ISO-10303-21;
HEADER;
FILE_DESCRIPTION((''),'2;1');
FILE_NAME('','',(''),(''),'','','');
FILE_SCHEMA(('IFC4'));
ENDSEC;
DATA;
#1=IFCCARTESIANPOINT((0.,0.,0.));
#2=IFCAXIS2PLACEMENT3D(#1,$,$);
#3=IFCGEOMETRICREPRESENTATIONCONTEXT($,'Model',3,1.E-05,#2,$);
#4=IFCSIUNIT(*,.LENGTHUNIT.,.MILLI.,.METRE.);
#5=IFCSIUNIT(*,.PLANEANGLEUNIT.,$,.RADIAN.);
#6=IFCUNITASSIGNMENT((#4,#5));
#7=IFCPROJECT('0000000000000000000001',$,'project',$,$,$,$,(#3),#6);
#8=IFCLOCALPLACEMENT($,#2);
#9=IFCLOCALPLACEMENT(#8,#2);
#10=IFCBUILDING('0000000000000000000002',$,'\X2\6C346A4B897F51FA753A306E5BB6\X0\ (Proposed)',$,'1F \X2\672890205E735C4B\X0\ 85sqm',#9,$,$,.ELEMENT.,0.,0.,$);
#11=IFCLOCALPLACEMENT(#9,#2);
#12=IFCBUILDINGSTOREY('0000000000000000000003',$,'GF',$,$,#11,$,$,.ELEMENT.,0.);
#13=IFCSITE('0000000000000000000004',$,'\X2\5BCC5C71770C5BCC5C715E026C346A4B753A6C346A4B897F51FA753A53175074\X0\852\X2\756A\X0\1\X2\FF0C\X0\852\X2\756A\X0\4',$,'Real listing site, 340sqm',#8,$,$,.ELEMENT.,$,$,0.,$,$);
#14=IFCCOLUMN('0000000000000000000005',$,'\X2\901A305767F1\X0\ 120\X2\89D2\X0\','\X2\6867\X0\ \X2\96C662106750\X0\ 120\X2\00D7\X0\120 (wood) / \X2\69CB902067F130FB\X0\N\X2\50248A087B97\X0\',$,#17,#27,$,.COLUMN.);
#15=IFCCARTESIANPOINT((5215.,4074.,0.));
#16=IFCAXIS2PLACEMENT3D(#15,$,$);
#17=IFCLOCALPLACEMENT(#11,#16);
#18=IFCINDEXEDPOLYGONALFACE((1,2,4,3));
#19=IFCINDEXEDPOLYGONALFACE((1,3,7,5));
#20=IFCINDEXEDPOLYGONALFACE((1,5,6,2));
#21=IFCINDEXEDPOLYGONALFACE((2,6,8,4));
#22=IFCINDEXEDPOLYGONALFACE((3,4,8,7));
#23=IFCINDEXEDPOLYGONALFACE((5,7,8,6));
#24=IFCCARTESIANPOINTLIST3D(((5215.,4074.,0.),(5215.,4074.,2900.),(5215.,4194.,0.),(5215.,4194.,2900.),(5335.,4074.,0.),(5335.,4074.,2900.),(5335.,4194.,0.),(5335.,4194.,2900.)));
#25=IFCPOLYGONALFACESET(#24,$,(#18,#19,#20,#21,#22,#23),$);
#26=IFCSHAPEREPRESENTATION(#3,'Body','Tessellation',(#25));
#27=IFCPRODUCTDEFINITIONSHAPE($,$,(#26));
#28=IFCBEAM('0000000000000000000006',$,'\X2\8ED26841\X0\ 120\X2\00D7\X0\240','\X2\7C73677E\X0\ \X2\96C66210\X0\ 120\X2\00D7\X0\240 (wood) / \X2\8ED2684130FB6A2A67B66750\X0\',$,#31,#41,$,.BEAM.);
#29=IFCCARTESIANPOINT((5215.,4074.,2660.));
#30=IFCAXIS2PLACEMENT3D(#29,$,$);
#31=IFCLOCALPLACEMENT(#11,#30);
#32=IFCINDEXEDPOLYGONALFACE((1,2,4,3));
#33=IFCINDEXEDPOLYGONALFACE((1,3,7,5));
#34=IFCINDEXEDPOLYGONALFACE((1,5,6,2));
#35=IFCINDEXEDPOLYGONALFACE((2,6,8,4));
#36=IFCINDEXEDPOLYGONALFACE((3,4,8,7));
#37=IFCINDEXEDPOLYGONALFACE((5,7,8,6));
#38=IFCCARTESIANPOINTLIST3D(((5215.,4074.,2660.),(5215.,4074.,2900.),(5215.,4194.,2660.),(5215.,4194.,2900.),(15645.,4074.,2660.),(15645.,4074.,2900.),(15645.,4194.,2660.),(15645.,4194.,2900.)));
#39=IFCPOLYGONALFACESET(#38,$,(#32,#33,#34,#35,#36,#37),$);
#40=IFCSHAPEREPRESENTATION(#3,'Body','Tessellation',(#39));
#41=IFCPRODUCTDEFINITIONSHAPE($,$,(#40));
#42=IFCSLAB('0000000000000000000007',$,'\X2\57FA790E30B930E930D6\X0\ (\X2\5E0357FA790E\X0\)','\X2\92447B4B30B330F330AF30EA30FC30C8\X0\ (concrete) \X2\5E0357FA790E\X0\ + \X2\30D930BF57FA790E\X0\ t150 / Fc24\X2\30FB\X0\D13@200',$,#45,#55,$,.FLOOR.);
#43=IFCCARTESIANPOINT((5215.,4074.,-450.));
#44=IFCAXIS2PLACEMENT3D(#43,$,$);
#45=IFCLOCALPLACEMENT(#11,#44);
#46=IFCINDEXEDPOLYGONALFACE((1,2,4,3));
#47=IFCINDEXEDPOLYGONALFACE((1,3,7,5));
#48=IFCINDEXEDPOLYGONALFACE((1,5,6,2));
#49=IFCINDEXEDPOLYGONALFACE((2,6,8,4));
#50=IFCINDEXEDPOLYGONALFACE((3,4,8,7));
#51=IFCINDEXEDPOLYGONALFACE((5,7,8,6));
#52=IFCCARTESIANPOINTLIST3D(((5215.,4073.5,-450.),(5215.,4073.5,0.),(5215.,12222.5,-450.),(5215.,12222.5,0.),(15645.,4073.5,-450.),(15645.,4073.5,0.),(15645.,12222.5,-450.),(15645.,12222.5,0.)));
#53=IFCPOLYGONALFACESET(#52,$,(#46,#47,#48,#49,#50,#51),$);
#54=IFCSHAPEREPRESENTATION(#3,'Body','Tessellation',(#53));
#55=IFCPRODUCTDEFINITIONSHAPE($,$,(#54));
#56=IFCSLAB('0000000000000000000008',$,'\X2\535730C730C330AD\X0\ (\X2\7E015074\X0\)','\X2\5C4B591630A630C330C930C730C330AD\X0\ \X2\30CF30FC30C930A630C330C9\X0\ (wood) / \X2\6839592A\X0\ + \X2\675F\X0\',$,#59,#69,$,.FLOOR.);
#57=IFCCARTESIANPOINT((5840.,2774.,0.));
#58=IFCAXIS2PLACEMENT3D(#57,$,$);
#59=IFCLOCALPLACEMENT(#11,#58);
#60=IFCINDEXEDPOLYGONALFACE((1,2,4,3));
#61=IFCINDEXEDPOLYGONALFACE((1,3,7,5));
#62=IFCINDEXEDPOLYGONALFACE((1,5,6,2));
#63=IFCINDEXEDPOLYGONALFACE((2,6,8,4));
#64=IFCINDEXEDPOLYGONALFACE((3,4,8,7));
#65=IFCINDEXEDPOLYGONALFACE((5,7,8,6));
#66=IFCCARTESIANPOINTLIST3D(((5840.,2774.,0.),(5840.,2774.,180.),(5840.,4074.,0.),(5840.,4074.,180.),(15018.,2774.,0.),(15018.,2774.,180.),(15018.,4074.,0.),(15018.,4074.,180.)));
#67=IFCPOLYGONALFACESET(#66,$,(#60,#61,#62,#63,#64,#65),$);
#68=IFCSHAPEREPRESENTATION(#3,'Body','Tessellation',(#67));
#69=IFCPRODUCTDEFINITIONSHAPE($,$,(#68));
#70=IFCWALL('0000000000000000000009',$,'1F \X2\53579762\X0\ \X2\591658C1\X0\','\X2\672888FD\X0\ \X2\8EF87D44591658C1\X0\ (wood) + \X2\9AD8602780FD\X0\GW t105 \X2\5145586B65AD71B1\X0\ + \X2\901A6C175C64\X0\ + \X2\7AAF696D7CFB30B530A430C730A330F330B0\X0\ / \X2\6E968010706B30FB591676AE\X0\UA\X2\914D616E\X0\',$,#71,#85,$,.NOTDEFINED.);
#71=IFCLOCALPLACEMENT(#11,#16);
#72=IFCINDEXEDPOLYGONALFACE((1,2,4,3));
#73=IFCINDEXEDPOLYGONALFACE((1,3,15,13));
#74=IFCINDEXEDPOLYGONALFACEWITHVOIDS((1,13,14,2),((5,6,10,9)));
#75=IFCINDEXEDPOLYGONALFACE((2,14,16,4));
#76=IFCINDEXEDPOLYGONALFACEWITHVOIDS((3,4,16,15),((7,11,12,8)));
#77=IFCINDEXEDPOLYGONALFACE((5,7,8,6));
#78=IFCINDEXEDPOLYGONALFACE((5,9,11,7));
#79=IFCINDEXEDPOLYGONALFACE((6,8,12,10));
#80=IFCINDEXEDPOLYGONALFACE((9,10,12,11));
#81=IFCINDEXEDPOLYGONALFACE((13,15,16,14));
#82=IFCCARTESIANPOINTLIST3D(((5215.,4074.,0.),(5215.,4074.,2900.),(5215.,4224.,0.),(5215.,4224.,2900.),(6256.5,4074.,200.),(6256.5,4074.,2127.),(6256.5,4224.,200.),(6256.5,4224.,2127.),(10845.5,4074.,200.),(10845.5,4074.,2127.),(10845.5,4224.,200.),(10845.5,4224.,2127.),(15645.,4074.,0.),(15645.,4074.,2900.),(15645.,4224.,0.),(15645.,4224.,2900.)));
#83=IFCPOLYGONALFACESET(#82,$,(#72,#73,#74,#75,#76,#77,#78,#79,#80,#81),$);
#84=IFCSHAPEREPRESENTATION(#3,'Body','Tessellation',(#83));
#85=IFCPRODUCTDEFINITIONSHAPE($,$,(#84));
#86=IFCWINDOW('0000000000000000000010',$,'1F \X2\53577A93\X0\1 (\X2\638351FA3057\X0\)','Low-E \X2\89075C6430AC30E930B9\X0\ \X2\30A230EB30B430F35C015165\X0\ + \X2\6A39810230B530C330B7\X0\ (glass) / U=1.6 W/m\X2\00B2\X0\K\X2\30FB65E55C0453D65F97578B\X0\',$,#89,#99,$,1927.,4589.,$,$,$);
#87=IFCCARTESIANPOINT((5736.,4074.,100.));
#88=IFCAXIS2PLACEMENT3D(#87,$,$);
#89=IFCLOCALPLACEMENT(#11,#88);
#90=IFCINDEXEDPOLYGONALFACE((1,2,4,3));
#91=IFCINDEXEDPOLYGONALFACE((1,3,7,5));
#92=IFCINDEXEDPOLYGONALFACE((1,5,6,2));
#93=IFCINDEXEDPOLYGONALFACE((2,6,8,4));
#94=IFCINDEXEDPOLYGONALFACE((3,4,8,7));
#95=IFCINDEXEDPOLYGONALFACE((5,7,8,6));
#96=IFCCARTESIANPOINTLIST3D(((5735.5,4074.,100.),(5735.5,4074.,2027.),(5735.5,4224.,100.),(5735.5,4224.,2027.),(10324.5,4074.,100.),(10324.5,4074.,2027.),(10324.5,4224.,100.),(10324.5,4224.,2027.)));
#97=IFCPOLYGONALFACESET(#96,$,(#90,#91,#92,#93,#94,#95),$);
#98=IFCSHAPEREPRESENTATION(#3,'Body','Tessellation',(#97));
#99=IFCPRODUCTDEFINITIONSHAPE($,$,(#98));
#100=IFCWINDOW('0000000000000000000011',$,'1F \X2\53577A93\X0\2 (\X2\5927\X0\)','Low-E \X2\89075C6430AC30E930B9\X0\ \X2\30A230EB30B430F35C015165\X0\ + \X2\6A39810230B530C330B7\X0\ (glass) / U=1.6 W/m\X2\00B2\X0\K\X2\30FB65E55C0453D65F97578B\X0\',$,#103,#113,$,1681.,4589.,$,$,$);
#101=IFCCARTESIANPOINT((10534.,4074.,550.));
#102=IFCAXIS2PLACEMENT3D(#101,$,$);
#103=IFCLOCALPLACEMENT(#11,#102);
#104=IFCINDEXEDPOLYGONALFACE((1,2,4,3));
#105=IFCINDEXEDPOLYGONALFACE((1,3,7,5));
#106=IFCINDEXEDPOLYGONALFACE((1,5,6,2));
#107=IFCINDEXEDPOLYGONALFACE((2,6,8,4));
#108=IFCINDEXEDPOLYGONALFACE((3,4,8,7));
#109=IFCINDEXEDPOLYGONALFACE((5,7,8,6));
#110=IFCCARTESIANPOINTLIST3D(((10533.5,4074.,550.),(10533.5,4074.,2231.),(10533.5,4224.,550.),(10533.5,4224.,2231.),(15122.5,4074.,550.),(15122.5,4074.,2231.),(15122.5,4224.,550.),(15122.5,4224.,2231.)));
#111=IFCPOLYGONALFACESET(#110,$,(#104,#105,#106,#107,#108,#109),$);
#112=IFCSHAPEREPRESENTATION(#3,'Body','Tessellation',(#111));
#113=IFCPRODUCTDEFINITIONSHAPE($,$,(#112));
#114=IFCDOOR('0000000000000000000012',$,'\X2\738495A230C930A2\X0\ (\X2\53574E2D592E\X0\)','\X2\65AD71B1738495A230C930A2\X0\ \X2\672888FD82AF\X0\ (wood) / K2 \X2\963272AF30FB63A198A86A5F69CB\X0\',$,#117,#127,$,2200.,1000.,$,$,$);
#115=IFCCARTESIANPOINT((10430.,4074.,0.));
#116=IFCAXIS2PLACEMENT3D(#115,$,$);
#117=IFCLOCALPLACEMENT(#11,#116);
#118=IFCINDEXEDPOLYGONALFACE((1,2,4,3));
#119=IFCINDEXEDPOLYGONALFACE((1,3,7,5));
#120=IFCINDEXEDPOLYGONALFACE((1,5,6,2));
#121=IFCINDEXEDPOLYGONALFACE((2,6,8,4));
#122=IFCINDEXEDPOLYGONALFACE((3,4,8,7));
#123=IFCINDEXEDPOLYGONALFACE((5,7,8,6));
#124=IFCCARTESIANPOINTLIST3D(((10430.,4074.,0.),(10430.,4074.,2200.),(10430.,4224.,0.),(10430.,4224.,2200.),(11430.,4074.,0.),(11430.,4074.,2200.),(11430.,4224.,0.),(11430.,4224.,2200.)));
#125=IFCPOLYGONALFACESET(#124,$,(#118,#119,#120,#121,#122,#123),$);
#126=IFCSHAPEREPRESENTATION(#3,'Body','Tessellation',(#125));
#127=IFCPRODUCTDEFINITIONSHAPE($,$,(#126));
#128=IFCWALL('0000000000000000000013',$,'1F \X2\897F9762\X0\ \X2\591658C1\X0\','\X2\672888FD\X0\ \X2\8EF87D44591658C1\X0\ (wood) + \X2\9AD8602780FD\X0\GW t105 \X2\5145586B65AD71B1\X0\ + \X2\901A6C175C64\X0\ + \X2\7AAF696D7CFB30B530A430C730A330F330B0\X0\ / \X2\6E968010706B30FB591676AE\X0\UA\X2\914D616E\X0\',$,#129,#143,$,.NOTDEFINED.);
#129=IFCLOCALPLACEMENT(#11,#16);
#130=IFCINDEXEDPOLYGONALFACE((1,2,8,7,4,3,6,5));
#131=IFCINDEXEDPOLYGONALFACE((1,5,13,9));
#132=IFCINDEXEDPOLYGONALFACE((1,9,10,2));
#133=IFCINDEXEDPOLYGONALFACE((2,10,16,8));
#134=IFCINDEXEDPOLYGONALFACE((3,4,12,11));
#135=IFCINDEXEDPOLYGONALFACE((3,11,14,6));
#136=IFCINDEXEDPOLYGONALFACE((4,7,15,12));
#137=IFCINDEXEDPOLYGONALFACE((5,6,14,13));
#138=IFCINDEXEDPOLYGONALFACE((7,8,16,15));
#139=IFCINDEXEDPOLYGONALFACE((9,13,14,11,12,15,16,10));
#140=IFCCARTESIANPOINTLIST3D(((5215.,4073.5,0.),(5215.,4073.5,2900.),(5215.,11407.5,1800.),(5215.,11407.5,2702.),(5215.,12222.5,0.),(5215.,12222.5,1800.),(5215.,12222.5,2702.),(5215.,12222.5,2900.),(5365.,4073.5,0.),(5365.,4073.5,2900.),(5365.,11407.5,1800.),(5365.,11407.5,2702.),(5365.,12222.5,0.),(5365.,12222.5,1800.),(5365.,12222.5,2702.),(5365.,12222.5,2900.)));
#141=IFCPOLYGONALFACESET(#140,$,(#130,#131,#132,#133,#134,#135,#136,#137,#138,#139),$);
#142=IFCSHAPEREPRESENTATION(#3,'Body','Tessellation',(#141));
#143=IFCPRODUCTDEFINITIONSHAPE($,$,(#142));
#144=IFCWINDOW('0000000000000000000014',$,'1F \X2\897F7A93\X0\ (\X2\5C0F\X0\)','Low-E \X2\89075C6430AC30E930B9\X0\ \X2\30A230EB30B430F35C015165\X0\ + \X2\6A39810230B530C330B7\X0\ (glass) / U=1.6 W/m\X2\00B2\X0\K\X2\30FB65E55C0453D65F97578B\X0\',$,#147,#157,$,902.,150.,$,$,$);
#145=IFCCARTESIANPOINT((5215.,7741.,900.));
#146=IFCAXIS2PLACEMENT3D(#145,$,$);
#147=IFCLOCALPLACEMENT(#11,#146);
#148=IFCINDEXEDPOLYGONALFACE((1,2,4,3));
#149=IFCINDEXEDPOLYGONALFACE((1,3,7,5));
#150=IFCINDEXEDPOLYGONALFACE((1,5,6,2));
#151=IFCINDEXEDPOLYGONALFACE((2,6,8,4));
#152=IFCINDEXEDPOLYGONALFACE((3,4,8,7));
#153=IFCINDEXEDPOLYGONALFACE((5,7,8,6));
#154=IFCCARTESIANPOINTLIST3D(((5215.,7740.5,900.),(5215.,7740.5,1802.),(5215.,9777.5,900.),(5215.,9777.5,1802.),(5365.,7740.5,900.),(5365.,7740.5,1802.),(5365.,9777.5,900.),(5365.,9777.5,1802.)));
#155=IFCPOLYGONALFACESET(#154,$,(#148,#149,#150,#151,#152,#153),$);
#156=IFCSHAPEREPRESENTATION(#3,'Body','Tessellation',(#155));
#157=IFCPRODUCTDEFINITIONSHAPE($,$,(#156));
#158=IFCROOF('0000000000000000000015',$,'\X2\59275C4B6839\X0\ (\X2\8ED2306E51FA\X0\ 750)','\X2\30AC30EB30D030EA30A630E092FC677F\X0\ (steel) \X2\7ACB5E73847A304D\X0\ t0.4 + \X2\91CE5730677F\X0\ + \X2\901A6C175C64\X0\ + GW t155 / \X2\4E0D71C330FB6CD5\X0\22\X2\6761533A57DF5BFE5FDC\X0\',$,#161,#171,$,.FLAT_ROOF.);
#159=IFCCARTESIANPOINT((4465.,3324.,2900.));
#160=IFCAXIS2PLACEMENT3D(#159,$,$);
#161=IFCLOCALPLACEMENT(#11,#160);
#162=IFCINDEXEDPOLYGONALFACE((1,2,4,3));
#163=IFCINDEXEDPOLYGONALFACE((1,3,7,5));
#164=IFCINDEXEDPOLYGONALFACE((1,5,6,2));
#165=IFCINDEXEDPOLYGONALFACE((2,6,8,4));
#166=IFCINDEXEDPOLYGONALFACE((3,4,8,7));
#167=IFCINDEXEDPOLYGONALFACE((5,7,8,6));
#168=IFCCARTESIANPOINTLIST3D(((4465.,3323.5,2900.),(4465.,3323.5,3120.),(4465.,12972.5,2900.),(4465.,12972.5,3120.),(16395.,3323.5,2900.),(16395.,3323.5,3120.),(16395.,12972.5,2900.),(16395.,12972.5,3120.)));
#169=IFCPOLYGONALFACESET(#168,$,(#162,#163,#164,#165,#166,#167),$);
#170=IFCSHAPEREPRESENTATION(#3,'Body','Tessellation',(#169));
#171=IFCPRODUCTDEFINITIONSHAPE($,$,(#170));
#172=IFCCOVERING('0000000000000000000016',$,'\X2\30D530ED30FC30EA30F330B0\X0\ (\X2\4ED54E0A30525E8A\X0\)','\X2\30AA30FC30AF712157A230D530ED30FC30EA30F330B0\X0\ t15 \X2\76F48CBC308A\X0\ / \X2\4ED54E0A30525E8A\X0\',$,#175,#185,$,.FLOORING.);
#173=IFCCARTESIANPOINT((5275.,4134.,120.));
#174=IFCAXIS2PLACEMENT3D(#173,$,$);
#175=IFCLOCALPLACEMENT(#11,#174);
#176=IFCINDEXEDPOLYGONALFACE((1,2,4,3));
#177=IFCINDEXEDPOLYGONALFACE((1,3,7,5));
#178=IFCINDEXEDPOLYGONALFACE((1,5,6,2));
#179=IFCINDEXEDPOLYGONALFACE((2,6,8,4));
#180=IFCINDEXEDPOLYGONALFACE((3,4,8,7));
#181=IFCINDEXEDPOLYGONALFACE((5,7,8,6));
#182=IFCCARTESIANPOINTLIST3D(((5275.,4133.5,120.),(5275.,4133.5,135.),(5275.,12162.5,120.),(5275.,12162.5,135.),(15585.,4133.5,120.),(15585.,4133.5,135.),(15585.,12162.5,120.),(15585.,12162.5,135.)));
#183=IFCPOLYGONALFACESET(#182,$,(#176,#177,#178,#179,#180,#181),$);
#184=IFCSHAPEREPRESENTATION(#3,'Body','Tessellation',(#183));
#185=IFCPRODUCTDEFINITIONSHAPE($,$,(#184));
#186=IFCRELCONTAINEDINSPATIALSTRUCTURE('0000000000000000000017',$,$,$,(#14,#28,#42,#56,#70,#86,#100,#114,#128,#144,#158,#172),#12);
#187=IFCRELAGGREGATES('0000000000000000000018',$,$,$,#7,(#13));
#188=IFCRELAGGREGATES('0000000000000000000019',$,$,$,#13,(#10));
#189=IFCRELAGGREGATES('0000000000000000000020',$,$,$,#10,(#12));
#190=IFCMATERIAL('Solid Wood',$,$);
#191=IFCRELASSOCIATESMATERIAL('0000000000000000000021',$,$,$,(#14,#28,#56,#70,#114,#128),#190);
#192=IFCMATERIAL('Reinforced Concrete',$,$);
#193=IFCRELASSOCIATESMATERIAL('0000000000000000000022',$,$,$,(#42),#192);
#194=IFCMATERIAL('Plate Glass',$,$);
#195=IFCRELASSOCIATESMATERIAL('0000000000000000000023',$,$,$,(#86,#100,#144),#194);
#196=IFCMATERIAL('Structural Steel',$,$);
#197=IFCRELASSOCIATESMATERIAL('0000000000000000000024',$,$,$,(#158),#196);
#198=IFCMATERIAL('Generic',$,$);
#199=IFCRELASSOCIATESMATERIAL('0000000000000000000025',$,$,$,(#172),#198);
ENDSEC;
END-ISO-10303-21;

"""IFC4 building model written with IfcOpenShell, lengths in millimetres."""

from ifc_helpers import new_model, si_unit, frame, frame_2d, origin, place, context, project, spatial, rectangle, extrude, material, element, fill, save


model = new_model("IFC4")

# Units and contexts
model_context = context("Model", 3, precision=1e-05, world=origin())
ifc_project = project(units=[si_unit("LENGTHUNIT", "METRE", prefix="MILLI"), si_unit("PLANEANGLEUNIT", "RADIAN")], contexts=[model_context])

# Site, building, storey
site_placement = place(None, origin())
site = spatial("IfcSite", under=ifc_project, at=site_placement, Name="富山県富山市水橋町水橋西出町北側852番1，852番4", ObjectType="Real listing site, 340sqm", CompositionType="ELEMENT", RefElevation=0.0)
building_placement = place(site_placement, origin())
building = spatial("IfcBuilding", under=site, at=building_placement, Name="水橋西出町の家 (Proposed)", ObjectType="1F 木造平屋 85sqm", CompositionType="ELEMENT", ElevationOfRefHeight=0.0, ElevationOfTerrain=0.0)
storey_placement = place(building_placement, origin())
storey = spatial("IfcBuildingStorey", under=building, at=storey_placement, Name="GF", CompositionType="ELEMENT", Elevation=0.0)

# Column
ifc_material_1 = material(Name="Solid Wood")
column_1_placement = place(storey_placement, frame((5215.0, 4074.0, 0.0)))
element("IfcColumn", 1, at=column_1_placement, inside=storey, material=ifc_material_1, Name="通し柱 120角", Description="桧 集成材 120×120 (wood) / 構造柱・N値計算", PredefinedType="COLUMN", context=model_context, shape_type="SweptSolid", body=[
    extrude(rectangle(XDim=120.0, YDim=120.0, at=frame_2d((60.0, 60.0))), frame((5215.0, 4074.0, 0.0)), (0.0, 0.0, 1.0), 2900.0),
])

# Beam
beam_1_placement = place(storey_placement, frame((5215.0, 4074.0, 2660.0)))
element("IfcBeam", 2, at=beam_1_placement, inside=storey, material=ifc_material_1, Name="軒桁 120×240", Description="米松 集成 120×240 (wood) / 軒桁・横架材", PredefinedType="BEAM", context=model_context, shape_type="SweptSolid", body=[
    extrude(rectangle(XDim=10430.0, YDim=120.0, at=frame_2d((5215.0, 60.0))), frame((5215.0, 4074.0, 2660.0)), (0.0, 0.0, 1.0), 240.0),
])

# Slabs
ifc_material_2 = material(Name="Reinforced Concrete")
slab_1_placement = place(storey_placement, frame((5215.0, 4074.0, -450.0)))
element("IfcSlab", 3, at=slab_1_placement, inside=storey, material=ifc_material_2, Name="基礎スラブ (布基礎)", Description="鉄筋コンクリート (concrete) 布基礎 + ベタ基礎 t150 / Fc24・D13@200", PredefinedType="FLOOR", context=model_context, shape_type="SweptSolid", body=[
    extrude(rectangle(XDim=10430.0, YDim=8149.0, at=frame_2d((5215.0, 4074.0))), frame((5215.0, 4074.0, -450.0)), (0.0, 0.0, 1.0), 450.0),
])
slab_2_placement = place(storey_placement, frame((5840.0, 2774.0, 0.0)))
element("IfcSlab", 4, at=slab_2_placement, inside=storey, material=ifc_material_1, Name="南デッキ (縁側)", Description="屋外ウッドデッキ ハードウッド (wood) / 根太 + 束", PredefinedType="FLOOR", context=model_context, shape_type="SweptSolid", body=[
    extrude(rectangle(XDim=9178.0, YDim=1300.0, at=frame_2d((4589.0, 650.0))), frame((5840.0, 2774.0, 0.0)), (0.0, 0.0, 1.0), 180.0),
])

# Wall, openings, windows, door
wall_1_placement = place(storey_placement, frame((5215.0, 4074.0, 0.0)))
wall_1 = element("IfcWall", 5, at=wall_1_placement, inside=storey, material=ifc_material_1, Name="1F 南面 外壁", Description="木製 軸組外壁 (wood) + 高性能GW t105 充填断熱 + 通気層 + 窯業系サイディング / 準耐火・外皮UA配慮", PredefinedType="NOTDEFINED", context=model_context, shape_type="SweptSolid", body=[
    extrude(rectangle(XDim=10430.0, YDim=150.0, at=frame_2d((5215.0, 75.0))), frame((5215.0, 4074.0, 0.0)), (0.0, 0.0, 1.0), 2900.0),
])
opening_1_placement = place(storey_placement, frame((5736.0, 4074.0, 100.0)))
opening_1 = element("IfcOpeningElement", 6, at=opening_1_placement, cuts=wall_1, PredefinedType="NOTDEFINED", context=model_context, shape_type="SweptSolid", body=[
    extrude(rectangle(XDim=4589.0, YDim=150.0, at=frame_2d((2294.0, 75.0))), frame((5736.0, 4074.0, 100.0)), (0.0, 0.0, 1.0), 1927.0),
])
opening_2_placement = place(storey_placement, frame((10534.0, 4074.0, 550.0)))
opening_2 = element("IfcOpeningElement", 7, at=opening_2_placement, cuts=wall_1, PredefinedType="NOTDEFINED", context=model_context, shape_type="SweptSolid", body=[
    extrude(rectangle(XDim=4589.0, YDim=150.0, at=frame_2d((2294.0, 75.0))), frame((10534.0, 4074.0, 550.0)), (0.0, 0.0, 1.0), 1681.0),
])
opening_3_placement = place(storey_placement, frame((10430.0, 4074.0, 0.0)))
opening_3 = element("IfcOpeningElement", 8, at=opening_3_placement, cuts=wall_1, PredefinedType="NOTDEFINED", context=model_context, shape_type="SweptSolid", body=[
    extrude(rectangle(XDim=1000.0, YDim=150.0, at=frame_2d((500.0, 75.0))), frame((10430.0, 4074.0, 0.0)), (0.0, 0.0, 1.0), 2200.0),
])
ifc_material_3 = material(Name="Plate Glass")
window_1_placement = place(storey_placement, frame((5736.0, 4074.0, 100.0)))
window_1 = element("IfcWindow", 9, at=window_1_placement, inside=storey, material=ifc_material_3, Name="1F 南窓1 (掃出し)", Description="Low-E 複層ガラス アルゴン封入 + 樹脂サッシ (glass) / U=1.6 W/m²K・日射取得型", OverallHeight=1927.0, OverallWidth=4589.0, context=model_context, shape_type="SweptSolid", body=[
    extrude(rectangle(XDim=4589.0, YDim=150.0, at=frame_2d((2294.0, 75.0))), frame((5736.0, 4074.0, 100.0)), (0.0, 0.0, 1.0), 1927.0),
])
fill(opening_1, window_1)
window_2_placement = place(storey_placement, frame((10534.0, 4074.0, 550.0)))
window_2 = element("IfcWindow", 10, at=window_2_placement, inside=storey, material=ifc_material_3, Name="1F 南窓2 (大)", Description="Low-E 複層ガラス アルゴン封入 + 樹脂サッシ (glass) / U=1.6 W/m²K・日射取得型", OverallHeight=1681.0, OverallWidth=4589.0, context=model_context, shape_type="SweptSolid", body=[
    extrude(rectangle(XDim=4589.0, YDim=150.0, at=frame_2d((2294.0, 75.0))), frame((10534.0, 4074.0, 550.0)), (0.0, 0.0, 1.0), 1681.0),
])
fill(opening_2, window_2)
door_placement = place(storey_placement, frame((10430.0, 4074.0, 0.0)))
door = element("IfcDoor", 11, at=door_placement, inside=storey, material=ifc_material_1, Name="玄関ドア (南中央)", Description="断熱玄関ドア 木製芯 (wood) / K2 防犯・採風機構", OverallHeight=2200.0, OverallWidth=1000.0, context=model_context, shape_type="SweptSolid", body=[
    extrude(rectangle(XDim=1000.0, YDim=150.0, at=frame_2d((500.0, 75.0))), frame((10430.0, 4074.0, 0.0)), (0.0, 0.0, 1.0), 2200.0),
])
fill(opening_3, door)

# Wall, opening, window
wall_2_placement = place(storey_placement, frame((5215.0, 4074.0, 0.0)))
wall_2 = element("IfcWall", 12, at=wall_2_placement, inside=storey, material=ifc_material_1, Name="1F 西面 外壁", Description="木製 軸組外壁 (wood) + 高性能GW t105 充填断熱 + 通気層 + 窯業系サイディング / 準耐火・外皮UA配慮", PredefinedType="NOTDEFINED", context=model_context, shape_type="SweptSolid", body=[
    extrude(rectangle(XDim=150.0, YDim=8149.0, at=frame_2d((75.0, 4074.0))), frame((5215.0, 4074.0, 0.0)), (0.0, 0.0, 1.0), 2900.0),
])
opening_4_placement = place(storey_placement, frame((5215.0, 7741.0, 900.0)))
opening_4 = element("IfcOpeningElement", 13, at=opening_4_placement, cuts=wall_2, PredefinedType="NOTDEFINED", context=model_context, shape_type="SweptSolid", body=[
    extrude(rectangle(XDim=150.0, YDim=2037.0, at=frame_2d((75.0, 1018.0))), frame((5215.0, 7741.0, 900.0)), (0.0, 0.0, 1.0), 902.0),
])
window_3_placement = place(storey_placement, frame((5215.0, 7741.0, 900.0)))
window_3 = element("IfcWindow", 14, at=window_3_placement, inside=storey, material=ifc_material_3, Name="1F 西窓 (小)", Description="Low-E 複層ガラス アルゴン封入 + 樹脂サッシ (glass) / U=1.6 W/m²K・日射取得型", OverallHeight=902.0, OverallWidth=150.0, context=model_context, shape_type="SweptSolid", body=[
    extrude(rectangle(XDim=150.0, YDim=2037.0, at=frame_2d((75.0, 1018.0))), frame((5215.0, 7741.0, 900.0)), (0.0, 0.0, 1.0), 902.0),
])
fill(opening_4, window_3)

# Roof
ifc_material_4 = material(Name="Structural Steel")
roof_placement = place(storey_placement, frame((4465.0, 3324.0, 2900.0)))
element("IfcRoof", 15, at=roof_placement, inside=storey, material=ifc_material_4, Name="大屋根 (軒の出 750)", Description="ガルバリウム鋼板 (steel) 立平葺き t0.4 + 野地板 + 通気層 + GW t155 / 不燃・法22条区域対応", PredefinedType="FLAT_ROOF", context=model_context, shape_type="SweptSolid", body=[
    extrude(rectangle(XDim=11930.0, YDim=9649.0, at=frame_2d((5965.0, 4824.0))), frame((4465.0, 3324.0, 2900.0)), (0.0, 0.0, 1.0), 220.0),
])

# Covering
ifc_material_5 = material(Name="Generic")
covering_1_placement = place(storey_placement, frame((5275.0, 4134.0, 120.0)))
element("IfcCovering", 16, at=covering_1_placement, inside=storey, material=ifc_material_5, Name="フローリング (仕上げ床)", Description="オーク無垢フローリング t15 直貼り / 仕上げ床", PredefinedType="FLOORING", context=model_context, shape_type="SweptSolid", body=[
    extrude(rectangle(XDim=10310.0, YDim=8029.0, at=frame_2d((5155.0, 4014.0))), frame((5275.0, 4134.0, 120.0)), (0.0, 0.0, 1.0), 15.0),
])

save(model, "model.ifc")
